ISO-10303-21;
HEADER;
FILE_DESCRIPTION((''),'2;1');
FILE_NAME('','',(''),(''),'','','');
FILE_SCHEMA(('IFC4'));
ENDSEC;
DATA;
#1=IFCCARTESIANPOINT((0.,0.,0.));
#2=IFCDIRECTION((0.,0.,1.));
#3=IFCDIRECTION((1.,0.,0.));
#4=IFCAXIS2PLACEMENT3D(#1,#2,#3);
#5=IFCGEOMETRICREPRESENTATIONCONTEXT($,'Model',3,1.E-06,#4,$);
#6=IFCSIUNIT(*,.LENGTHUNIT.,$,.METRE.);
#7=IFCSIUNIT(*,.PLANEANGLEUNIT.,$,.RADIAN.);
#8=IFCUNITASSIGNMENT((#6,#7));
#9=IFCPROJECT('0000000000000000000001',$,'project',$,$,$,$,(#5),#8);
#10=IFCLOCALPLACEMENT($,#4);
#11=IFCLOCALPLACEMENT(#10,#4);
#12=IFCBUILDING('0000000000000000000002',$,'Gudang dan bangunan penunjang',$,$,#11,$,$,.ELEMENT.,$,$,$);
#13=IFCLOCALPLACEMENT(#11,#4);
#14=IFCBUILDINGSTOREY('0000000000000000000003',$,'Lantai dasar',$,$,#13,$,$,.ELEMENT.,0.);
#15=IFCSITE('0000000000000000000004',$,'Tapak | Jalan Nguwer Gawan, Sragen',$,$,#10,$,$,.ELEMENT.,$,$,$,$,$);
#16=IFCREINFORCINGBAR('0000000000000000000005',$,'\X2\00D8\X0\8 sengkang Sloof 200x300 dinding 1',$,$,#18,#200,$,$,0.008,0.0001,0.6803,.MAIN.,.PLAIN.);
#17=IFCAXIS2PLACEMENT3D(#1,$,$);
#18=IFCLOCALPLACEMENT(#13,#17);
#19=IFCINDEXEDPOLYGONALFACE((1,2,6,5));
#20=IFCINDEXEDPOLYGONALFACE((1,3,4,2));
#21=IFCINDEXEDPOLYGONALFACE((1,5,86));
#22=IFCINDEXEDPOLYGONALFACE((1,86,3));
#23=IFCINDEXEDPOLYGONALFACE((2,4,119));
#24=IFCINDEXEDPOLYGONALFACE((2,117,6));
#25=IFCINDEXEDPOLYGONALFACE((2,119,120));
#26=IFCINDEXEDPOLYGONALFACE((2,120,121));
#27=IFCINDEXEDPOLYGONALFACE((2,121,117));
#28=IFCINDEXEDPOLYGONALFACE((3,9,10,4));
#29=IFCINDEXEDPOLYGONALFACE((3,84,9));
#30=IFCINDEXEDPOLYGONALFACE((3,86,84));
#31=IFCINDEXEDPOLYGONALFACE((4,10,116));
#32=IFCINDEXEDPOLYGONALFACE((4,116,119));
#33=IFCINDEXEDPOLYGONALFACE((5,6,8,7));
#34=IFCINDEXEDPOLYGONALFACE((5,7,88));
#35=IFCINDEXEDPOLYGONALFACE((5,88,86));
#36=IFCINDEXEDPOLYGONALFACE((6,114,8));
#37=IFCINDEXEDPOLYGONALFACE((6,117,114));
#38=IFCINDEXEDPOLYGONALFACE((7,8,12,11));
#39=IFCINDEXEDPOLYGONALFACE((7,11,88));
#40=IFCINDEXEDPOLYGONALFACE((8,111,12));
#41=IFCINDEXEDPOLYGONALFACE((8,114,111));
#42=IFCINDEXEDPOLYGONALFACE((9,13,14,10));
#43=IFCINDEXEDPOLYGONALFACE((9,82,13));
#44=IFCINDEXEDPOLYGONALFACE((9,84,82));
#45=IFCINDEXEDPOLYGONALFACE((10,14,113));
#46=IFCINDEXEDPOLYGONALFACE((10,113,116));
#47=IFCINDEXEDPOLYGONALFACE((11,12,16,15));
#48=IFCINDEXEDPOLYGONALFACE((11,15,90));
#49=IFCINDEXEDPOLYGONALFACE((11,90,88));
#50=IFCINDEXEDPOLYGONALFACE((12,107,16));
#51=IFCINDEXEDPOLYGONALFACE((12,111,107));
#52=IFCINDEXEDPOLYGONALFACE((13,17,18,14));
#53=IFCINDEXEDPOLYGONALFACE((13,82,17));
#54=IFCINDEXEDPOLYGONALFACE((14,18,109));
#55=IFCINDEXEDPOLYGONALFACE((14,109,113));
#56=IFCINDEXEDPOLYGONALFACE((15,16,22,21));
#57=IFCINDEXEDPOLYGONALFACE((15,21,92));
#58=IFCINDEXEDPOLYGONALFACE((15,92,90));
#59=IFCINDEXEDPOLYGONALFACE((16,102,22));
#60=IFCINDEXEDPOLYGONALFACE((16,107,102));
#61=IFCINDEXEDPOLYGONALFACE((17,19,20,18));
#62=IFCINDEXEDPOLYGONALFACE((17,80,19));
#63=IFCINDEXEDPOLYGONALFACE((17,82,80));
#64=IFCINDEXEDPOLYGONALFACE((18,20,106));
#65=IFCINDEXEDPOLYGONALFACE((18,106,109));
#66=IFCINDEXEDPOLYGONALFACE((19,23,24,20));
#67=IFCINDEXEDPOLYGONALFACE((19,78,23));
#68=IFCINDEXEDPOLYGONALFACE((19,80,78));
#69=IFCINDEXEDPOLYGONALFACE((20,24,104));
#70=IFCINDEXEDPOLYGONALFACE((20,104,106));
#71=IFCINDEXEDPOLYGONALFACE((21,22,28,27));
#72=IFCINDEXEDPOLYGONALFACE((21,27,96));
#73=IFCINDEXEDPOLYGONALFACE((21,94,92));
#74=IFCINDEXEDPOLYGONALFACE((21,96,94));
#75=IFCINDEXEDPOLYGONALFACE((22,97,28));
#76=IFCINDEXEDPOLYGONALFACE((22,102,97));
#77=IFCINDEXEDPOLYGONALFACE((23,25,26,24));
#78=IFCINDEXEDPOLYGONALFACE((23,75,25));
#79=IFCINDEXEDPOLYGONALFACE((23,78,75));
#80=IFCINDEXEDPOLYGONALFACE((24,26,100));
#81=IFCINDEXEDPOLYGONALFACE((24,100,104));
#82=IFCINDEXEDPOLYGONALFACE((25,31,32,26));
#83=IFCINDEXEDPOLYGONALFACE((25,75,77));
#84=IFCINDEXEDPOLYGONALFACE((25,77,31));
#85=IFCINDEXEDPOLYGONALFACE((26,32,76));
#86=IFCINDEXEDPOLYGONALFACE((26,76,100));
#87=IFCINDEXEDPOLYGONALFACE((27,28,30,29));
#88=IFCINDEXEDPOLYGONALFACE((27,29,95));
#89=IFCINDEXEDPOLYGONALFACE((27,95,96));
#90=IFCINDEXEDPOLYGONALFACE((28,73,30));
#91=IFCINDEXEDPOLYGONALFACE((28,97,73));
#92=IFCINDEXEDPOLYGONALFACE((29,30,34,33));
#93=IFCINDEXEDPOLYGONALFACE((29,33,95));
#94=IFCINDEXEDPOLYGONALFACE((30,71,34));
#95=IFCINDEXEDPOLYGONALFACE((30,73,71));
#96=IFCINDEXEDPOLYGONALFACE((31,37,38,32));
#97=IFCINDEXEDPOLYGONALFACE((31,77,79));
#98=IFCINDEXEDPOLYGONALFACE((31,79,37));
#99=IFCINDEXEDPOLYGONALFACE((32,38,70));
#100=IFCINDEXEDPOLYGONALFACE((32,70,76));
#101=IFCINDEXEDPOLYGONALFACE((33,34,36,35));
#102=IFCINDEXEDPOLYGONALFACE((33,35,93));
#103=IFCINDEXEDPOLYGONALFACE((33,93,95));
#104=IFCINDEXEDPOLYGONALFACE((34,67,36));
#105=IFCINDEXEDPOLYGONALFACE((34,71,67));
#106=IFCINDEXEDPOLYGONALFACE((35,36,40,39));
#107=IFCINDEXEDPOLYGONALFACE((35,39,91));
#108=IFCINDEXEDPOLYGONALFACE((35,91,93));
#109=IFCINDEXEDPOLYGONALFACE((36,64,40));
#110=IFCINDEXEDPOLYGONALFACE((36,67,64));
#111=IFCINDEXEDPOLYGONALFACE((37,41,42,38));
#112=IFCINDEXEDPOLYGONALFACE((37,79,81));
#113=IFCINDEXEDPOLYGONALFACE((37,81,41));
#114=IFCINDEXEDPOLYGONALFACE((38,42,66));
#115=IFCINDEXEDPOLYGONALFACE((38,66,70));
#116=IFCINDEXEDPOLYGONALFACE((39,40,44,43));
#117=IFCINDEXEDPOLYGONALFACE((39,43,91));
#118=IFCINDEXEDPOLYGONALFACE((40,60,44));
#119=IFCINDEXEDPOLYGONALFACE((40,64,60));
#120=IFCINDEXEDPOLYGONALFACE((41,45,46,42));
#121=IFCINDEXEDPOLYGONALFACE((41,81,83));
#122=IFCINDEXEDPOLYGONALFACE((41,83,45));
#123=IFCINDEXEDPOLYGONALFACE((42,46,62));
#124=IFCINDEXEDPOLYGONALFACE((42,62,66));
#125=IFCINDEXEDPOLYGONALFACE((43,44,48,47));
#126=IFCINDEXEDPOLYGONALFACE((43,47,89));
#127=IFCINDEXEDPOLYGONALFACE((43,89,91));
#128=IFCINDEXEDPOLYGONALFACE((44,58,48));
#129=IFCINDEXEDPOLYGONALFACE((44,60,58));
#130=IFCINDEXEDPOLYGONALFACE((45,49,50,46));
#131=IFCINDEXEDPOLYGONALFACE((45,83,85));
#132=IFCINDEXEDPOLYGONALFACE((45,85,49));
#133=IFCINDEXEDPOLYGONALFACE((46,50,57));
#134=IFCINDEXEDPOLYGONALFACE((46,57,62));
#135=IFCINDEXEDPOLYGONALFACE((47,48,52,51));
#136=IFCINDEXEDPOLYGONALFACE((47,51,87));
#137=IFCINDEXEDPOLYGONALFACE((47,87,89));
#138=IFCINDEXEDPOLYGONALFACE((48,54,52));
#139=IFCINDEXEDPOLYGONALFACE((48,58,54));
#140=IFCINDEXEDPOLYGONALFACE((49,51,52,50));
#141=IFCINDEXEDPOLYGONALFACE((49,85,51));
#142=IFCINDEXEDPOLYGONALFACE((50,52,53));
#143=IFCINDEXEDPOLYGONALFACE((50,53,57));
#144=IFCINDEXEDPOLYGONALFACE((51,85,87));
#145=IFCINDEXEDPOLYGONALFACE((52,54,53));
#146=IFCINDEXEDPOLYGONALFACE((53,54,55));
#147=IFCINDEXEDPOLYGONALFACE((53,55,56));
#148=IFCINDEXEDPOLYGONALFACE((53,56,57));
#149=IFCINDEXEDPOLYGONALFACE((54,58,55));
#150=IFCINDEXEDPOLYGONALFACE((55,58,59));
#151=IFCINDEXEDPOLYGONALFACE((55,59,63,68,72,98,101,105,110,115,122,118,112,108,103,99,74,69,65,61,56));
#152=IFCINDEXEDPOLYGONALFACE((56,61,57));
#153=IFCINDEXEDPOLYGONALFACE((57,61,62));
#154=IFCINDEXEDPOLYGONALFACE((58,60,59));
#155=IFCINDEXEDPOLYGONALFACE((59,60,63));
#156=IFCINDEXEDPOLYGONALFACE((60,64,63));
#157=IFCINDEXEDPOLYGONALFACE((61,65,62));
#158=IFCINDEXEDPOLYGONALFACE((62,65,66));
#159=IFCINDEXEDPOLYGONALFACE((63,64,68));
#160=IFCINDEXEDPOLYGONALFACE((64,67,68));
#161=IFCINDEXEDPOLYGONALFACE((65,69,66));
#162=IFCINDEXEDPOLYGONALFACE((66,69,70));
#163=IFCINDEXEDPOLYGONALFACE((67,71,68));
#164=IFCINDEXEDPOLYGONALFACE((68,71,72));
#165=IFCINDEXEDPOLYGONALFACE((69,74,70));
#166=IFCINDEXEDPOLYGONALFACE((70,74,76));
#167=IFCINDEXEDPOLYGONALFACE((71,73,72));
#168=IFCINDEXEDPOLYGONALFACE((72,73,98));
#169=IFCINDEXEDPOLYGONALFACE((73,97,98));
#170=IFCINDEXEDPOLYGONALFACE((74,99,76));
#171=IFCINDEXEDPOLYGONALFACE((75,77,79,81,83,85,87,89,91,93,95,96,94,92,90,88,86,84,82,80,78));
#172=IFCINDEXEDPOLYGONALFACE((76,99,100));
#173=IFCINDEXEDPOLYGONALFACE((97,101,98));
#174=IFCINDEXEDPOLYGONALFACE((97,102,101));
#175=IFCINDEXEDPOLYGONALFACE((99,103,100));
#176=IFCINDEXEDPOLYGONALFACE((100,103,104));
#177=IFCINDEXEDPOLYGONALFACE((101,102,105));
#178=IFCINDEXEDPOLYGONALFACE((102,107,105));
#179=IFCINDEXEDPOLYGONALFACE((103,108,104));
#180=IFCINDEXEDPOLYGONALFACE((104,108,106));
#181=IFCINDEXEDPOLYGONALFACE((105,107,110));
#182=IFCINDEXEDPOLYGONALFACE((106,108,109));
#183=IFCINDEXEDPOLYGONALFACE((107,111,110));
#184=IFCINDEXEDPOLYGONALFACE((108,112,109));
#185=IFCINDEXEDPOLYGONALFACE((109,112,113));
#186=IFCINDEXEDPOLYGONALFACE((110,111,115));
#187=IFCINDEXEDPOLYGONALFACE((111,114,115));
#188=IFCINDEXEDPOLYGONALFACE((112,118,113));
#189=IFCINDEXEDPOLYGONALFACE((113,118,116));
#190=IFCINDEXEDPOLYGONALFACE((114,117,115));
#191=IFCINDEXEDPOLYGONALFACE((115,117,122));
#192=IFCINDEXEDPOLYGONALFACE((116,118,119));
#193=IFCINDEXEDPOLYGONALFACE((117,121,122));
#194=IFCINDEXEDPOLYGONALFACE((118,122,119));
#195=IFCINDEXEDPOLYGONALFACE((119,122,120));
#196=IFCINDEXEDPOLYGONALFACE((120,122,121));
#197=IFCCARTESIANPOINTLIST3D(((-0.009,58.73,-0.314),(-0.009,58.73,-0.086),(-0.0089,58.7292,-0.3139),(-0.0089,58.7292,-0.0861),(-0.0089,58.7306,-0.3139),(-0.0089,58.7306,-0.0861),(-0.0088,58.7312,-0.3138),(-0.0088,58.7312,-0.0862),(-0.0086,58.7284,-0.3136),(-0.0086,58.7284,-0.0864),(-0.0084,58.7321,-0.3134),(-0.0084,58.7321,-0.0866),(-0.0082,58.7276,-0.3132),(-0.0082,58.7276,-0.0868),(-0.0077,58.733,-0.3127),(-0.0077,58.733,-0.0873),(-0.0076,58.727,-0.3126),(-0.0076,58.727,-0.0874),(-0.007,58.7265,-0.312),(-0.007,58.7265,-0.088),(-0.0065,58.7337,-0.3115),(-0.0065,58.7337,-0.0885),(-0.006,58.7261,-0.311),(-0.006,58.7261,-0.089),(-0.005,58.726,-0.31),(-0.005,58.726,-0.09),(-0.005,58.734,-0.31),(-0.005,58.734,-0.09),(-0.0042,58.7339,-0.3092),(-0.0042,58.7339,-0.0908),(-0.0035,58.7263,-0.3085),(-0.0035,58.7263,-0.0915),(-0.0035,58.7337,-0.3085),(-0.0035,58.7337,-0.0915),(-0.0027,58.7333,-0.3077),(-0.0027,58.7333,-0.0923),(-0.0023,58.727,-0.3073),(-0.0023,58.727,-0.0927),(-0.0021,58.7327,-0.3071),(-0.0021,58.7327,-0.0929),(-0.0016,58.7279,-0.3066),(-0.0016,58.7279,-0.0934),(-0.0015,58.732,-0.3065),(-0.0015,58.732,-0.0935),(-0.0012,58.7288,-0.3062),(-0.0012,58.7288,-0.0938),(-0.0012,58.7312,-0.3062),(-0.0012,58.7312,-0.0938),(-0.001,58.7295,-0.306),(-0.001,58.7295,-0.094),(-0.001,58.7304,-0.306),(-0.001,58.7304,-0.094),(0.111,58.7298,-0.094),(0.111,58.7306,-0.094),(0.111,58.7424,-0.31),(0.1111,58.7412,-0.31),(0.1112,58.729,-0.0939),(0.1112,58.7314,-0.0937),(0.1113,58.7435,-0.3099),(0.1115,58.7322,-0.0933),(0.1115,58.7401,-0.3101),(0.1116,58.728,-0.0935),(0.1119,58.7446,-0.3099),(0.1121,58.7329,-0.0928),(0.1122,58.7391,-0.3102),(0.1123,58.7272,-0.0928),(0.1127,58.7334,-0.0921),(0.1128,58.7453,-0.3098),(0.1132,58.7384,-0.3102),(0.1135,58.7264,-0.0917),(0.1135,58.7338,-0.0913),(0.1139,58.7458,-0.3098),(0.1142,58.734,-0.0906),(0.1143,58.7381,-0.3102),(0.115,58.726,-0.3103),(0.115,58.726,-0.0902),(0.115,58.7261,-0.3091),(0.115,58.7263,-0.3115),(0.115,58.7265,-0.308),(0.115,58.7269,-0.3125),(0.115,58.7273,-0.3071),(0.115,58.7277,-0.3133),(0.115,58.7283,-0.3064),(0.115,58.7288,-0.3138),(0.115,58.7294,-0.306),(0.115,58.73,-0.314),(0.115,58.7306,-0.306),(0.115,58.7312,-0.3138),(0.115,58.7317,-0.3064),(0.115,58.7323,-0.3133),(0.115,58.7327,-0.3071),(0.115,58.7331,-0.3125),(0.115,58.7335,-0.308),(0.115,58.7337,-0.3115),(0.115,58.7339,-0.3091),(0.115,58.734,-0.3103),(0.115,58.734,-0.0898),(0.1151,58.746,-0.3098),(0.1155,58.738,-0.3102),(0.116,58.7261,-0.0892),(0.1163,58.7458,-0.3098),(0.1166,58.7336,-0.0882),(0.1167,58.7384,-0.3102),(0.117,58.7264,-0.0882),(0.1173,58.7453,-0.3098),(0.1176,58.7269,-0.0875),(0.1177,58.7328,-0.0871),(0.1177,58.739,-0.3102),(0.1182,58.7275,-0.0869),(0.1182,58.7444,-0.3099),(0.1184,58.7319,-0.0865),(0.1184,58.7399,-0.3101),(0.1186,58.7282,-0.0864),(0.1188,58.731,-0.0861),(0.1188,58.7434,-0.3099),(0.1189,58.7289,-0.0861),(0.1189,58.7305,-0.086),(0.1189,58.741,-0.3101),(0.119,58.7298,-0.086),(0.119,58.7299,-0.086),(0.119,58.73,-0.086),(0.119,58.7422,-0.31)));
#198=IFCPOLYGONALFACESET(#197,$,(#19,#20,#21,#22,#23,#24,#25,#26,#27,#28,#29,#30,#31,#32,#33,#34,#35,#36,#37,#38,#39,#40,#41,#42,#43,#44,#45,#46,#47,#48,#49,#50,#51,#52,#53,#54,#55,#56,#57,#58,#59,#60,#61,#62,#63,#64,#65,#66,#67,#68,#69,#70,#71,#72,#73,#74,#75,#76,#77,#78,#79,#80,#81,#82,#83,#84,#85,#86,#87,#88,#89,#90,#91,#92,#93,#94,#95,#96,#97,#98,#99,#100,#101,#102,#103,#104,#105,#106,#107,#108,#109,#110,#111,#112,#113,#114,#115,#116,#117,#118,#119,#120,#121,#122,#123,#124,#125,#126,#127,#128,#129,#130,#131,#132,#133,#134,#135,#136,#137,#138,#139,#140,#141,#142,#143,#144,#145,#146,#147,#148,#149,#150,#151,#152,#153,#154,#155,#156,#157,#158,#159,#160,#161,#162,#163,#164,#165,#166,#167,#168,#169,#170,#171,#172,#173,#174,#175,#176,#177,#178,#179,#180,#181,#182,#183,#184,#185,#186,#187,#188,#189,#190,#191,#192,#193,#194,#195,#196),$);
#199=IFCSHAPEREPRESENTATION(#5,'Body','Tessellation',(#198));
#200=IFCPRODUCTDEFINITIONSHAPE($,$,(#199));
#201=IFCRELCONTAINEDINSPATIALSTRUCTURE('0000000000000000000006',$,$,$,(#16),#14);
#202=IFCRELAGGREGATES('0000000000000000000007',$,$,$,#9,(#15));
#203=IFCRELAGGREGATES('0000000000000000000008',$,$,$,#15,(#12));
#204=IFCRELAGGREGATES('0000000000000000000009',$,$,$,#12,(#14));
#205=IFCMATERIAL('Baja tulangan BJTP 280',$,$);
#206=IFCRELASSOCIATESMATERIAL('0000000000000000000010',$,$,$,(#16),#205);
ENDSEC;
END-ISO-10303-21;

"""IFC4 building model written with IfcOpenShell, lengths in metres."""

from ifc_helpers import new_model, entity, si_unit, origin_with_axes, place, context, project, spatial, material, element, save


model = new_model("IFC4")

# Units and contexts
model_context = context("Model", 3, precision=1e-06, world=origin_with_axes())
ifc_project = project(units=[si_unit("LENGTHUNIT", "METRE"), si_unit("PLANEANGLEUNIT", "RADIAN")], contexts=[model_context])

# Site, building, storey
site_placement = place(None, origin_with_axes())
site = spatial("IfcSite", under=ifc_project, at=site_placement, Name="Tapak | Jalan Nguwer Gawan, Sragen", CompositionType="ELEMENT")
building_placement = place(site_placement, origin_with_axes())
building = spatial("IfcBuilding", under=site, at=building_placement, Name="Gudang dan bangunan penunjang", CompositionType="ELEMENT")
storey_placement = place(building_placement, origin_with_axes())
storey = spatial("IfcBuildingStorey", under=building, at=storey_placement, Name="Lantai dasar", CompositionType="ELEMENT", Elevation=0.0)

# Shared definitions
placement = place(None, origin_with_axes())

# Reinforcing bar
ifc_material_1 = material(Name="Baja tulangan BJTP 280")
element("IfcReinforcingBar", 1, at=placement, inside=storey, material=ifc_material_1, Name="Ø8 sengkang Sloof 200x300 dinding 1", BarLength=0.6803, BarSurface="PLAIN", CrossSectionArea=0.0001, NominalDiameter=0.008, PredefinedType="MAIN", context=model_context, shape_type="AdvancedSweptSolid", body=[
    entity("IfcSweptDiskSolid", entity("IfcPolyline", [entity("IfcCartesianPoint", [0.115, 58.73, -0.31]), entity("IfcCartesianPoint", [-0.005, 58.73, -0.31]), entity("IfcCartesianPoint", [-0.005, 58.73, -0.09]), entity("IfcCartesianPoint", [0.115, 58.73, -0.09]), entity("IfcCartesianPoint", [0.115, 58.742, -0.31])]), 0.004),
])

save(model, "model.ifc")
